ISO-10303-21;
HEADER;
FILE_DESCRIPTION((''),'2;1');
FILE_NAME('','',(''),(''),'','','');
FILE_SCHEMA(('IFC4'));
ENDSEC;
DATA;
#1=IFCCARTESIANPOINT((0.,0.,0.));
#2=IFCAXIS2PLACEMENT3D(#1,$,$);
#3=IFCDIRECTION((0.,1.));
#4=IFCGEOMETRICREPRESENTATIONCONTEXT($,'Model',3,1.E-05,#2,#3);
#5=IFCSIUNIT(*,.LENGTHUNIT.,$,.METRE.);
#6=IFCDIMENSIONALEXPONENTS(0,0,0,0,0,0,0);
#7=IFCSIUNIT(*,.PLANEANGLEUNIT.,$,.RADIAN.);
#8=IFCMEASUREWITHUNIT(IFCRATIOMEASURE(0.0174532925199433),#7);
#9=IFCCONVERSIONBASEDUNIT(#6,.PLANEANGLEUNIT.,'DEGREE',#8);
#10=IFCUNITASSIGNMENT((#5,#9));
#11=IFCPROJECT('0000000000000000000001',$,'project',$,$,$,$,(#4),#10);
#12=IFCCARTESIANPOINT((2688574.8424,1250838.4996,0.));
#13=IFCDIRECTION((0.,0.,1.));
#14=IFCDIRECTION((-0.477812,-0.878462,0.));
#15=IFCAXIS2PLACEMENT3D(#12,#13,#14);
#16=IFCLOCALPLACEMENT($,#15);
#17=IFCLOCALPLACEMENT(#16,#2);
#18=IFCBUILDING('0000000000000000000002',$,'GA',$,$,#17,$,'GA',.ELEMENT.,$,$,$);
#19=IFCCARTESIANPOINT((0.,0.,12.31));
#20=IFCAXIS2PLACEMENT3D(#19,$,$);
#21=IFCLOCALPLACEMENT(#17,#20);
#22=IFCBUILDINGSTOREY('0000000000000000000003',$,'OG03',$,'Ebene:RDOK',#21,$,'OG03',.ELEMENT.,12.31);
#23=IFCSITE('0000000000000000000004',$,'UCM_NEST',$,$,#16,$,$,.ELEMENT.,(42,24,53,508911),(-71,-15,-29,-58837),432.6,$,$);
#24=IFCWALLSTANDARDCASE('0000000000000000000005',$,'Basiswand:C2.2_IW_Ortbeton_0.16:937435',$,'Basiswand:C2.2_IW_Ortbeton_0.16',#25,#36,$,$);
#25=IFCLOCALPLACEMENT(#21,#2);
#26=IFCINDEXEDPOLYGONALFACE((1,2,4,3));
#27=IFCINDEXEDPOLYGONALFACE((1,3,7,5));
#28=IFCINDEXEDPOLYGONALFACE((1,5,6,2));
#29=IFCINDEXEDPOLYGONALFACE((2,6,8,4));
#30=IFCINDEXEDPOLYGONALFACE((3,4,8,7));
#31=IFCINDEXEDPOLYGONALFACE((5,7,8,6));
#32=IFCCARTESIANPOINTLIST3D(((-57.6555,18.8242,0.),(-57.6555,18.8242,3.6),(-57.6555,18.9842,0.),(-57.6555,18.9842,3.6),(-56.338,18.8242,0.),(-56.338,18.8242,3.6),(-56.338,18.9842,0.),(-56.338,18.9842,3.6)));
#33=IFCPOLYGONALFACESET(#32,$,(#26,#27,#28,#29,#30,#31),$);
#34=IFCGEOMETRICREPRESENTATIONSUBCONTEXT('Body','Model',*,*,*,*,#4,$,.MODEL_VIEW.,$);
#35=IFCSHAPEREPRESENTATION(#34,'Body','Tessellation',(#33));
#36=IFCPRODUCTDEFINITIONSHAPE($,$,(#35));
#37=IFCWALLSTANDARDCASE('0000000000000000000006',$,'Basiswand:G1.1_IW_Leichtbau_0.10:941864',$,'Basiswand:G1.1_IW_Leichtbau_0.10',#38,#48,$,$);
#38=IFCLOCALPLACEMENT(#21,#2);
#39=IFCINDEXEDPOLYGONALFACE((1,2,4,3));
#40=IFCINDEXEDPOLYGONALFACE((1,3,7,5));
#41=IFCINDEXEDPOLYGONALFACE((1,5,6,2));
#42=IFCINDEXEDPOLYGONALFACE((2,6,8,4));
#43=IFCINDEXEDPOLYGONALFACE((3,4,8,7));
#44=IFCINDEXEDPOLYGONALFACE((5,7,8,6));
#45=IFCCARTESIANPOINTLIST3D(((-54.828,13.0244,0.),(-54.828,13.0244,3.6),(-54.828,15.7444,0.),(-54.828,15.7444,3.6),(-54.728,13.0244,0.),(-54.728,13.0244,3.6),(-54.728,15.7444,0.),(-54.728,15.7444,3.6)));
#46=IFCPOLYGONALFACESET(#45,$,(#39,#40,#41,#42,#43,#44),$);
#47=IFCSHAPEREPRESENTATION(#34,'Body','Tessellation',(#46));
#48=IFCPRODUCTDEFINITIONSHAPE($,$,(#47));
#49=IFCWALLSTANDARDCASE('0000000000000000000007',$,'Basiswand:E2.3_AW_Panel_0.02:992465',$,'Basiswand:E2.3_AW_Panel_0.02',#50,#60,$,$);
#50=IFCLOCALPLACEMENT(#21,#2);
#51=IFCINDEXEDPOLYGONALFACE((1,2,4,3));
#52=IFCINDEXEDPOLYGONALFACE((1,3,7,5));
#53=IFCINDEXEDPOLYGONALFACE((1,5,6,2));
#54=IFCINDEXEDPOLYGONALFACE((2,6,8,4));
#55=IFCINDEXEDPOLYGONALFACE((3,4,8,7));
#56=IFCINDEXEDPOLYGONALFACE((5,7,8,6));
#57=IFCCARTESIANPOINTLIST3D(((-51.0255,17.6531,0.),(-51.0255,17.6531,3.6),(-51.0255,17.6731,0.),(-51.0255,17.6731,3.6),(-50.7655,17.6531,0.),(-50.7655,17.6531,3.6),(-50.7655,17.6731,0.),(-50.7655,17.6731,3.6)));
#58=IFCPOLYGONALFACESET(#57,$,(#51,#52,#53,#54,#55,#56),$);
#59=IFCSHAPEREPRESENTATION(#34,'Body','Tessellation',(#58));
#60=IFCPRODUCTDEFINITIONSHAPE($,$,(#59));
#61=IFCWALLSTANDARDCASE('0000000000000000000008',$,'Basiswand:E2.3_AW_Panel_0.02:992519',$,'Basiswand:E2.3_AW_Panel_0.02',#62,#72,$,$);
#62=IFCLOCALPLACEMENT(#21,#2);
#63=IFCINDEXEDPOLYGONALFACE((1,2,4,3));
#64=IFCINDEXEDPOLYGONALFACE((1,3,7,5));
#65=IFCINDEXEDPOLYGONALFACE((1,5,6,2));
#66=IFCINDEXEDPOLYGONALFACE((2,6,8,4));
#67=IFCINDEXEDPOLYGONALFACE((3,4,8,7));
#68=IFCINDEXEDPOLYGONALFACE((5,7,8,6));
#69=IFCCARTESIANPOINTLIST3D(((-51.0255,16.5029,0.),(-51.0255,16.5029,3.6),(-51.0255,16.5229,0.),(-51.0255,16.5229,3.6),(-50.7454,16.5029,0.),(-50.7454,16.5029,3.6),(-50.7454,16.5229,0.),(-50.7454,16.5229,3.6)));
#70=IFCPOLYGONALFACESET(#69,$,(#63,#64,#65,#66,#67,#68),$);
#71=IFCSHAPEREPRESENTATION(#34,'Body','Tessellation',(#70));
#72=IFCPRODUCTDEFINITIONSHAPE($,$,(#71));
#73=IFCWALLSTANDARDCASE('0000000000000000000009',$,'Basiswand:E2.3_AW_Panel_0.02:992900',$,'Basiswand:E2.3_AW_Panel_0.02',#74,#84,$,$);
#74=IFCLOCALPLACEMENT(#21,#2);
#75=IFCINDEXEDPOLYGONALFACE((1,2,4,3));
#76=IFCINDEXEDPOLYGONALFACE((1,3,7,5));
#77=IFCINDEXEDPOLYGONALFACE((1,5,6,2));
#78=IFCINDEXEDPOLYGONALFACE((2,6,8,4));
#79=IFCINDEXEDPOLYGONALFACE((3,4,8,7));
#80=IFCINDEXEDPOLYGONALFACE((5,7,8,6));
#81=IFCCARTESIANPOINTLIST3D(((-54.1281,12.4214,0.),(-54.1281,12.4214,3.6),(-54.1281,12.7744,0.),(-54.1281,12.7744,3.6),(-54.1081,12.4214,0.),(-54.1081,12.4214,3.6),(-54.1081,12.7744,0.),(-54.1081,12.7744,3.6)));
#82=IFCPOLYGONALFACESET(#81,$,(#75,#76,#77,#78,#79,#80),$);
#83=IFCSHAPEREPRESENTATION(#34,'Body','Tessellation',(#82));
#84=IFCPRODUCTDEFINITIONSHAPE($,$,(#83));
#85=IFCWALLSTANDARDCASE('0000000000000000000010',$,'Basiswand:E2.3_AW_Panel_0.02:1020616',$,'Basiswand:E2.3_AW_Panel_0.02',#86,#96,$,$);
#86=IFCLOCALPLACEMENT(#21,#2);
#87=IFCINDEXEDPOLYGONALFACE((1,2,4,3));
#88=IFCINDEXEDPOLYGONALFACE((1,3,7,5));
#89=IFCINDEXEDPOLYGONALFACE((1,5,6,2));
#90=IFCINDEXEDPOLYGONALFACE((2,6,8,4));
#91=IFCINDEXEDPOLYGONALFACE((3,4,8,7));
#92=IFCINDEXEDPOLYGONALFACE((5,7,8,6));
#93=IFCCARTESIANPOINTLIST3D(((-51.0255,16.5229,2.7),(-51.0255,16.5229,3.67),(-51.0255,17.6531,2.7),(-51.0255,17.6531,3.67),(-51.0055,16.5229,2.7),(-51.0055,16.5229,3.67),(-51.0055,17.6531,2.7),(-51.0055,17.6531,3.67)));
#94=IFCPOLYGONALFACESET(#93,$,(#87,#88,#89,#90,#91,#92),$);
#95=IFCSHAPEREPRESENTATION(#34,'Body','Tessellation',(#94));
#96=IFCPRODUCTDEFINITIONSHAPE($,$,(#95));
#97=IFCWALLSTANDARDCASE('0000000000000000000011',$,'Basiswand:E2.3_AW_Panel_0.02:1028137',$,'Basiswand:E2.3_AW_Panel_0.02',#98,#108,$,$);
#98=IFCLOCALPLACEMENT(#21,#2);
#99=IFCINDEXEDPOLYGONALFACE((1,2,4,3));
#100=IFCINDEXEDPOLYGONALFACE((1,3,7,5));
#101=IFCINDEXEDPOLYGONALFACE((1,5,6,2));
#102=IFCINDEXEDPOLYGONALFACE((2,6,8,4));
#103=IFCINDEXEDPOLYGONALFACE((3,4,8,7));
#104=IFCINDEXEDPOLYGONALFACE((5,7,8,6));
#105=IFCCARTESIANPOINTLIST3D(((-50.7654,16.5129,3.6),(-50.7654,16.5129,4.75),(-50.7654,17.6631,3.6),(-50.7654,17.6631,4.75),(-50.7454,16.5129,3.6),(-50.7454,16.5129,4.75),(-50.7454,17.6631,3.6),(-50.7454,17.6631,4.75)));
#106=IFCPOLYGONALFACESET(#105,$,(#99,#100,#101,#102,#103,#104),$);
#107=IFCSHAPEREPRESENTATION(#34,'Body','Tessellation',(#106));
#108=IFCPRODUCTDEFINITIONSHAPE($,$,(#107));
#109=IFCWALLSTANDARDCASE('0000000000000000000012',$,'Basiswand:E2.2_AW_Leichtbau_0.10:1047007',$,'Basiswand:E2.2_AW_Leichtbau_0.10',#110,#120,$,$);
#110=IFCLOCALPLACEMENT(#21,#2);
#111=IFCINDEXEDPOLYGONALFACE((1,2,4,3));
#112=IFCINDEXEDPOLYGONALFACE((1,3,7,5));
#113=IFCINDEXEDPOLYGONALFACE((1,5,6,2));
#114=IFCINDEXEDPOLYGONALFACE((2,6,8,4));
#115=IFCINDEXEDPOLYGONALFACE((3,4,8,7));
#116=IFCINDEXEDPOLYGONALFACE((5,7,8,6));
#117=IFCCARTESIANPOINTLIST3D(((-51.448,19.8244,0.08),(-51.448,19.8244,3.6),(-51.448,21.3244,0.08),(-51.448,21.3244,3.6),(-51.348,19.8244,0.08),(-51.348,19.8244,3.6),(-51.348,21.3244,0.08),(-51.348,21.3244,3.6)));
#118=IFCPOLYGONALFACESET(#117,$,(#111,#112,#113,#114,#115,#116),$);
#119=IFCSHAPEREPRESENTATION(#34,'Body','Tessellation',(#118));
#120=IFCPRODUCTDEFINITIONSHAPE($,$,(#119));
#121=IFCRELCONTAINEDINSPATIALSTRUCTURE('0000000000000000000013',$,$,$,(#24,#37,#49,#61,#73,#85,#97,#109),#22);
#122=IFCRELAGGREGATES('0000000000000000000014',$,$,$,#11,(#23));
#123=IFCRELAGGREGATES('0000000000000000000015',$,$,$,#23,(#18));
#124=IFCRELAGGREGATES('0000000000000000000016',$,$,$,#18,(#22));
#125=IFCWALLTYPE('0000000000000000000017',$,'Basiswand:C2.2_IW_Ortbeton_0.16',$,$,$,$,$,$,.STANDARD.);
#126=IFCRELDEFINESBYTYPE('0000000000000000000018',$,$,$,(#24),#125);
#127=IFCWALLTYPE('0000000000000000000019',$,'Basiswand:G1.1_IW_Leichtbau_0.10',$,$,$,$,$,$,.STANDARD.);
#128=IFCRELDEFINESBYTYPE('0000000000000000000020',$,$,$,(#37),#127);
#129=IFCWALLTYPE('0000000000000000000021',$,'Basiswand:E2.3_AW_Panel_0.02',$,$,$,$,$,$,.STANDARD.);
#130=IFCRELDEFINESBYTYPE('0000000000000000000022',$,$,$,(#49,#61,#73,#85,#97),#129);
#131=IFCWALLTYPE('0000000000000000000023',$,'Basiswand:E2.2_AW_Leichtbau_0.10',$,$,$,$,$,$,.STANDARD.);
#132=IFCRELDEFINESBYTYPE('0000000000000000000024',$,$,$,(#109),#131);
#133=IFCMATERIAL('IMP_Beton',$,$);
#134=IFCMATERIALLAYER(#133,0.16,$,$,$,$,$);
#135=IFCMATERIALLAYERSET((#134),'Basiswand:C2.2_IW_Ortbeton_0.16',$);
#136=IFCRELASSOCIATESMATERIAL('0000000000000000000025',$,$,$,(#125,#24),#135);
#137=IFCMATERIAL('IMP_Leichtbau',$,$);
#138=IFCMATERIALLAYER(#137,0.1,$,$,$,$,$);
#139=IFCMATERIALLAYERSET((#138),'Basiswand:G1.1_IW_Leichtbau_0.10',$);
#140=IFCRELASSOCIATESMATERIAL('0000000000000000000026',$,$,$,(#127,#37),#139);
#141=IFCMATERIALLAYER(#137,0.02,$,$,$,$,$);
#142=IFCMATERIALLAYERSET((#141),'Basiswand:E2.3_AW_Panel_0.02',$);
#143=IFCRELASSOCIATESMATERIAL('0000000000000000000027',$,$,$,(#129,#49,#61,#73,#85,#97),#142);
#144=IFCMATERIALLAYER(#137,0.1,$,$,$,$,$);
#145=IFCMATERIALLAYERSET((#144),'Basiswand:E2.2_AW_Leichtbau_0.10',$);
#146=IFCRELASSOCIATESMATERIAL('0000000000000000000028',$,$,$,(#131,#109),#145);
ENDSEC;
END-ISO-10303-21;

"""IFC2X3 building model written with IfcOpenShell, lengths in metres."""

from ifc_helpers import new_model, entity, si_unit, converted_unit, direction, frame, frame_2d, origin, place, context, subcontext, project, spatial, polyline, rectangle, extrude, clip, bounded_halfspace, material, layer, layer_set, layer_usage, type_object, element, save


model = new_model("IFC2X3")

# Units and contexts
model_context = context("Model", 3, precision=1e-05, world=origin(), true_north=direction((0.0, 1.0)))
body_context = subcontext(model_context, "Body", "Model", "MODEL_VIEW")
ifc_project = project(units=[si_unit("LENGTHUNIT", "METRE"), converted_unit("PLANEANGLEUNIT", "DEGREE", entity("IfcRatioMeasure", 0.0174532925199433), si_unit("PLANEANGLEUNIT", "RADIAN"), dimensions=[0, 0, 0, 0, 0, 0, 0])], contexts=[model_context])

# Site, building, storey
site_placement = place(None, frame((2688574.8424, 1250838.4996, 0.0), z_axis=(0.0, 0.0, 1.0), x_axis=(-0.477812, -0.878462, 0.0)))
site = spatial("IfcSite", under=ifc_project, at=site_placement, Name="UCM_NEST", CompositionType="ELEMENT", RefLatitude=(42, 24, 53, 508911), RefLongitude=(-71, -15, -29, -58837), RefElevation=432.6)
building_placement = place(site_placement, origin())
building = spatial("IfcBuilding", under=site, at=building_placement, Name="GA", LongName="GA", CompositionType="ELEMENT")
storey_placement = place(building_placement, frame((0.0, 0.0, 12.31)))
storey = spatial("IfcBuildingStorey", under=building, at=storey_placement, Name="OG03", ObjectType="Ebene:RDOK", LongName="OG03", CompositionType="ELEMENT", Elevation=12.31)

# Shared definitions
ifc_material_1 = material(Name="IMP_Beton")

# Walls
ifc_material_2 = material(Name="IMP_Leichtbau")
ifc_layer_1 = layer(ifc_material_1, 0.16)
ifc_layer_set_1 = layer_set([ifc_layer_1], Name="Basiswand:C2.2_IW_Ortbeton_0.16")
ifc_layer_usage_1 = layer_usage(ifc_layer_set_1, "AXIS2", "NEGATIVE", 0.08)
wall_type_1 = type_object("IfcWallType", Name="Basiswand:C2.2_IW_Ortbeton_0.16", PredefinedType="STANDARD", material=ifc_layer_set_1)
wall_1_placement = place(storey_placement, frame((-56.338, 18.9042, 0.0), z_axis=(0.0, 0.0, 1.0), x_axis=(-1.0, 0.0, 0.0)))
element("IfcWallStandardCase", 1, at=wall_1_placement, inside=storey, type_object=wall_type_1, material=ifc_layer_usage_1, Name="Basiswand:C2.2_IW_Ortbeton_0.16:937435", ObjectType="Basiswand:C2.2_IW_Ortbeton_0.16", context=body_context, shape_type="SweptSolid", body=[
    extrude(rectangle(XDim=1.3175, YDim=0.16, at=frame_2d((0.6588, 0.0), x_axis=(-1.0, 0.0))), origin(), (0.0, 0.0, 1.0), 3.6),
])
ifc_layer_2 = layer(ifc_material_2, 0.1)
ifc_layer_set_2 = layer_set([ifc_layer_2], Name="Basiswand:G1.1_IW_Leichtbau_0.10")
ifc_layer_usage_2 = layer_usage(ifc_layer_set_2, "AXIS2", "NEGATIVE", 0.05)
wall_type_2 = type_object("IfcWallType", Name="Basiswand:G1.1_IW_Leichtbau_0.10", PredefinedType="STANDARD", material=ifc_layer_set_2)
wall_2_placement = place(storey_placement, frame((-54.778, 15.7444, 0.0), z_axis=(0.0, 0.0, 1.0), x_axis=(0.0, -1.0, 0.0)))
element("IfcWallStandardCase", 2, at=wall_2_placement, inside=storey, type_object=wall_type_2, material=ifc_layer_usage_2, Name="Basiswand:G1.1_IW_Leichtbau_0.10:941864", ObjectType="Basiswand:G1.1_IW_Leichtbau_0.10", context=body_context, shape_type="SweptSolid", body=[
    extrude(rectangle(XDim=2.72, YDim=0.1, at=frame_2d((1.36, 0.0), x_axis=(-1.0, 0.0))), origin(), (0.0, 0.0, 1.0), 3.6),
])
ifc_layer_3 = layer(ifc_material_2, 0.02)
ifc_layer_set_3 = layer_set([ifc_layer_3], Name="Basiswand:E2.3_AW_Panel_0.02")
ifc_layer_usage_3 = layer_usage(ifc_layer_set_3, "AXIS2", "NEGATIVE", 0.01)
wall_type_3 = type_object("IfcWallType", Name="Basiswand:E2.3_AW_Panel_0.02", PredefinedType="STANDARD", material=ifc_layer_set_3)
wall_3_placement = place(storey_placement, frame((-50.7655, 17.6631, 0.0), z_axis=(0.0, 0.0, 1.0), x_axis=(-1.0, 0.0, 0.0)))
element("IfcWallStandardCase", 3, at=wall_3_placement, inside=storey, type_object=wall_type_3, material=ifc_layer_usage_3, Name="Basiswand:E2.3_AW_Panel_0.02:992465", ObjectType="Basiswand:E2.3_AW_Panel_0.02", context=body_context, shape_type="SweptSolid", body=[
    extrude(rectangle(XDim=0.26, YDim=0.02, at=frame_2d((0.13, 0.0), x_axis=(-1.0, 0.0))), origin(), (0.0, 0.0, 1.0), 3.6),
])
ifc_layer_usage_4 = layer_usage(ifc_layer_set_3, "AXIS2", "NEGATIVE", 0.01)
wall_4_placement = place(storey_placement, frame((-51.0255, 16.5129, 0.0)))
element("IfcWallStandardCase", 4, at=wall_4_placement, inside=storey, type_object=wall_type_3, material=ifc_layer_usage_4, Name="Basiswand:E2.3_AW_Panel_0.02:992519", ObjectType="Basiswand:E2.3_AW_Panel_0.02", context=body_context, shape_type="SweptSolid", body=[
    extrude(rectangle(XDim=0.28, YDim=0.02, at=frame_2d((0.14, 0.0), x_axis=(-1.0, 0.0))), origin(), (0.0, 0.0, 1.0), 3.6),
])
ifc_layer_usage_5 = layer_usage(ifc_layer_set_3, "AXIS2", "NEGATIVE", 0.01)
wall_5_placement = place(storey_placement, frame((-54.1181, 12.7744, 0.0), z_axis=(0.0, 0.0, 1.0), x_axis=(0.0, -1.0, 0.0)))
element("IfcWallStandardCase", 5, at=wall_5_placement, inside=storey, type_object=wall_type_3, material=ifc_layer_usage_5, Name="Basiswand:E2.3_AW_Panel_0.02:992900", ObjectType="Basiswand:E2.3_AW_Panel_0.02", context=body_context, shape_type="SweptSolid", body=[
    extrude(rectangle(XDim=0.353, YDim=0.02, at=frame_2d((0.1765, 0.0), x_axis=(-1.0, 0.0))), origin(), (0.0, 0.0, 1.0), 3.6),
])
ifc_layer_usage_6 = layer_usage(ifc_layer_set_3, "AXIS2", "NEGATIVE", 0.01)
wall_6_placement = place(storey_placement, frame((-51.0155, 17.6531, 2.7), z_axis=(0.0, 0.0, 1.0), x_axis=(0.0, -1.0, 0.0)))
element("IfcWallStandardCase", 6, at=wall_6_placement, inside=storey, type_object=wall_type_3, material=ifc_layer_usage_6, Name="Basiswand:E2.3_AW_Panel_0.02:1020616", ObjectType="Basiswand:E2.3_AW_Panel_0.02", context=body_context, shape_type="SweptSolid", body=[
    extrude(rectangle(XDim=1.1302, YDim=0.02, at=frame_2d((0.5651, 0.0), x_axis=(-1.0, 0.0))), origin(), (0.0, 0.0, 1.0), 0.97),
])
ifc_layer_usage_7 = layer_usage(ifc_layer_set_3, "AXIS2", "NEGATIVE", 0.01)
wall_7_placement = place(storey_placement, frame((-50.7554, 16.5129, 3.6), z_axis=(0.0, 0.0, 1.0), x_axis=(0.0, 1.0, 0.0)))
element("IfcWallStandardCase", 7, at=wall_7_placement, inside=storey, type_object=wall_type_3, material=ifc_layer_usage_7, Name="Basiswand:E2.3_AW_Panel_0.02:1028137", ObjectType="Basiswand:E2.3_AW_Panel_0.02", context=body_context, shape_type="SweptSolid", body=[
    extrude(rectangle(XDim=1.1502, YDim=0.02, at=frame_2d((0.5751, 0.0), x_axis=(-1.0, 0.0))), origin(), (0.0, 0.0, 1.0), 1.15),
])

# Wall
ifc_layer_4 = layer(ifc_material_2, 0.1)
ifc_layer_set_4 = layer_set([ifc_layer_4], Name="Basiswand:E2.2_AW_Leichtbau_0.10")
ifc_layer_usage_8 = layer_usage(ifc_layer_set_4, "AXIS2", "NEGATIVE", 0.05)
wall_type_4 = type_object("IfcWallType", Name="Basiswand:E2.2_AW_Leichtbau_0.10", PredefinedType="STANDARD", material=ifc_layer_set_4)
wall_8_placement = place(storey_placement, frame((-51.398, 19.8244, 0.08), z_axis=(0.0, 0.0, 1.0), x_axis=(0.0, 1.0, 0.0)))
element("IfcWallStandardCase", 8, at=wall_8_placement, inside=storey, type_object=wall_type_4, material=ifc_layer_usage_8, Name="Basiswand:E2.2_AW_Leichtbau_0.10:1047007", ObjectType="Basiswand:E2.2_AW_Leichtbau_0.10", context=body_context, shape_type="Clipping", body=[
    clip(extrude(rectangle(XDim=1.5, YDim=0.1, at=frame_2d((0.75, 0.0), x_axis=(-1.0, 0.0))), origin(), (0.0, 0.0, 1.0), 3.52), bounded_halfspace(frame((1.5, -0.05, 0.0), z_axis=(0.0, 0.0, 1.0), x_axis=(0.0, 1.0, 0.0)), True, frame((1.5, -0.05, 0.0), z_axis=(0.0, 0.0, 1.0), x_axis=(0.0, 1.0, 0.0)), polyline([(0.0, 0.0), (0.1, 0.0), (0.1, 1.5), (0.0, 1.5), (0.0, 0.0)]))),
])

save(model, "model.ifc")
